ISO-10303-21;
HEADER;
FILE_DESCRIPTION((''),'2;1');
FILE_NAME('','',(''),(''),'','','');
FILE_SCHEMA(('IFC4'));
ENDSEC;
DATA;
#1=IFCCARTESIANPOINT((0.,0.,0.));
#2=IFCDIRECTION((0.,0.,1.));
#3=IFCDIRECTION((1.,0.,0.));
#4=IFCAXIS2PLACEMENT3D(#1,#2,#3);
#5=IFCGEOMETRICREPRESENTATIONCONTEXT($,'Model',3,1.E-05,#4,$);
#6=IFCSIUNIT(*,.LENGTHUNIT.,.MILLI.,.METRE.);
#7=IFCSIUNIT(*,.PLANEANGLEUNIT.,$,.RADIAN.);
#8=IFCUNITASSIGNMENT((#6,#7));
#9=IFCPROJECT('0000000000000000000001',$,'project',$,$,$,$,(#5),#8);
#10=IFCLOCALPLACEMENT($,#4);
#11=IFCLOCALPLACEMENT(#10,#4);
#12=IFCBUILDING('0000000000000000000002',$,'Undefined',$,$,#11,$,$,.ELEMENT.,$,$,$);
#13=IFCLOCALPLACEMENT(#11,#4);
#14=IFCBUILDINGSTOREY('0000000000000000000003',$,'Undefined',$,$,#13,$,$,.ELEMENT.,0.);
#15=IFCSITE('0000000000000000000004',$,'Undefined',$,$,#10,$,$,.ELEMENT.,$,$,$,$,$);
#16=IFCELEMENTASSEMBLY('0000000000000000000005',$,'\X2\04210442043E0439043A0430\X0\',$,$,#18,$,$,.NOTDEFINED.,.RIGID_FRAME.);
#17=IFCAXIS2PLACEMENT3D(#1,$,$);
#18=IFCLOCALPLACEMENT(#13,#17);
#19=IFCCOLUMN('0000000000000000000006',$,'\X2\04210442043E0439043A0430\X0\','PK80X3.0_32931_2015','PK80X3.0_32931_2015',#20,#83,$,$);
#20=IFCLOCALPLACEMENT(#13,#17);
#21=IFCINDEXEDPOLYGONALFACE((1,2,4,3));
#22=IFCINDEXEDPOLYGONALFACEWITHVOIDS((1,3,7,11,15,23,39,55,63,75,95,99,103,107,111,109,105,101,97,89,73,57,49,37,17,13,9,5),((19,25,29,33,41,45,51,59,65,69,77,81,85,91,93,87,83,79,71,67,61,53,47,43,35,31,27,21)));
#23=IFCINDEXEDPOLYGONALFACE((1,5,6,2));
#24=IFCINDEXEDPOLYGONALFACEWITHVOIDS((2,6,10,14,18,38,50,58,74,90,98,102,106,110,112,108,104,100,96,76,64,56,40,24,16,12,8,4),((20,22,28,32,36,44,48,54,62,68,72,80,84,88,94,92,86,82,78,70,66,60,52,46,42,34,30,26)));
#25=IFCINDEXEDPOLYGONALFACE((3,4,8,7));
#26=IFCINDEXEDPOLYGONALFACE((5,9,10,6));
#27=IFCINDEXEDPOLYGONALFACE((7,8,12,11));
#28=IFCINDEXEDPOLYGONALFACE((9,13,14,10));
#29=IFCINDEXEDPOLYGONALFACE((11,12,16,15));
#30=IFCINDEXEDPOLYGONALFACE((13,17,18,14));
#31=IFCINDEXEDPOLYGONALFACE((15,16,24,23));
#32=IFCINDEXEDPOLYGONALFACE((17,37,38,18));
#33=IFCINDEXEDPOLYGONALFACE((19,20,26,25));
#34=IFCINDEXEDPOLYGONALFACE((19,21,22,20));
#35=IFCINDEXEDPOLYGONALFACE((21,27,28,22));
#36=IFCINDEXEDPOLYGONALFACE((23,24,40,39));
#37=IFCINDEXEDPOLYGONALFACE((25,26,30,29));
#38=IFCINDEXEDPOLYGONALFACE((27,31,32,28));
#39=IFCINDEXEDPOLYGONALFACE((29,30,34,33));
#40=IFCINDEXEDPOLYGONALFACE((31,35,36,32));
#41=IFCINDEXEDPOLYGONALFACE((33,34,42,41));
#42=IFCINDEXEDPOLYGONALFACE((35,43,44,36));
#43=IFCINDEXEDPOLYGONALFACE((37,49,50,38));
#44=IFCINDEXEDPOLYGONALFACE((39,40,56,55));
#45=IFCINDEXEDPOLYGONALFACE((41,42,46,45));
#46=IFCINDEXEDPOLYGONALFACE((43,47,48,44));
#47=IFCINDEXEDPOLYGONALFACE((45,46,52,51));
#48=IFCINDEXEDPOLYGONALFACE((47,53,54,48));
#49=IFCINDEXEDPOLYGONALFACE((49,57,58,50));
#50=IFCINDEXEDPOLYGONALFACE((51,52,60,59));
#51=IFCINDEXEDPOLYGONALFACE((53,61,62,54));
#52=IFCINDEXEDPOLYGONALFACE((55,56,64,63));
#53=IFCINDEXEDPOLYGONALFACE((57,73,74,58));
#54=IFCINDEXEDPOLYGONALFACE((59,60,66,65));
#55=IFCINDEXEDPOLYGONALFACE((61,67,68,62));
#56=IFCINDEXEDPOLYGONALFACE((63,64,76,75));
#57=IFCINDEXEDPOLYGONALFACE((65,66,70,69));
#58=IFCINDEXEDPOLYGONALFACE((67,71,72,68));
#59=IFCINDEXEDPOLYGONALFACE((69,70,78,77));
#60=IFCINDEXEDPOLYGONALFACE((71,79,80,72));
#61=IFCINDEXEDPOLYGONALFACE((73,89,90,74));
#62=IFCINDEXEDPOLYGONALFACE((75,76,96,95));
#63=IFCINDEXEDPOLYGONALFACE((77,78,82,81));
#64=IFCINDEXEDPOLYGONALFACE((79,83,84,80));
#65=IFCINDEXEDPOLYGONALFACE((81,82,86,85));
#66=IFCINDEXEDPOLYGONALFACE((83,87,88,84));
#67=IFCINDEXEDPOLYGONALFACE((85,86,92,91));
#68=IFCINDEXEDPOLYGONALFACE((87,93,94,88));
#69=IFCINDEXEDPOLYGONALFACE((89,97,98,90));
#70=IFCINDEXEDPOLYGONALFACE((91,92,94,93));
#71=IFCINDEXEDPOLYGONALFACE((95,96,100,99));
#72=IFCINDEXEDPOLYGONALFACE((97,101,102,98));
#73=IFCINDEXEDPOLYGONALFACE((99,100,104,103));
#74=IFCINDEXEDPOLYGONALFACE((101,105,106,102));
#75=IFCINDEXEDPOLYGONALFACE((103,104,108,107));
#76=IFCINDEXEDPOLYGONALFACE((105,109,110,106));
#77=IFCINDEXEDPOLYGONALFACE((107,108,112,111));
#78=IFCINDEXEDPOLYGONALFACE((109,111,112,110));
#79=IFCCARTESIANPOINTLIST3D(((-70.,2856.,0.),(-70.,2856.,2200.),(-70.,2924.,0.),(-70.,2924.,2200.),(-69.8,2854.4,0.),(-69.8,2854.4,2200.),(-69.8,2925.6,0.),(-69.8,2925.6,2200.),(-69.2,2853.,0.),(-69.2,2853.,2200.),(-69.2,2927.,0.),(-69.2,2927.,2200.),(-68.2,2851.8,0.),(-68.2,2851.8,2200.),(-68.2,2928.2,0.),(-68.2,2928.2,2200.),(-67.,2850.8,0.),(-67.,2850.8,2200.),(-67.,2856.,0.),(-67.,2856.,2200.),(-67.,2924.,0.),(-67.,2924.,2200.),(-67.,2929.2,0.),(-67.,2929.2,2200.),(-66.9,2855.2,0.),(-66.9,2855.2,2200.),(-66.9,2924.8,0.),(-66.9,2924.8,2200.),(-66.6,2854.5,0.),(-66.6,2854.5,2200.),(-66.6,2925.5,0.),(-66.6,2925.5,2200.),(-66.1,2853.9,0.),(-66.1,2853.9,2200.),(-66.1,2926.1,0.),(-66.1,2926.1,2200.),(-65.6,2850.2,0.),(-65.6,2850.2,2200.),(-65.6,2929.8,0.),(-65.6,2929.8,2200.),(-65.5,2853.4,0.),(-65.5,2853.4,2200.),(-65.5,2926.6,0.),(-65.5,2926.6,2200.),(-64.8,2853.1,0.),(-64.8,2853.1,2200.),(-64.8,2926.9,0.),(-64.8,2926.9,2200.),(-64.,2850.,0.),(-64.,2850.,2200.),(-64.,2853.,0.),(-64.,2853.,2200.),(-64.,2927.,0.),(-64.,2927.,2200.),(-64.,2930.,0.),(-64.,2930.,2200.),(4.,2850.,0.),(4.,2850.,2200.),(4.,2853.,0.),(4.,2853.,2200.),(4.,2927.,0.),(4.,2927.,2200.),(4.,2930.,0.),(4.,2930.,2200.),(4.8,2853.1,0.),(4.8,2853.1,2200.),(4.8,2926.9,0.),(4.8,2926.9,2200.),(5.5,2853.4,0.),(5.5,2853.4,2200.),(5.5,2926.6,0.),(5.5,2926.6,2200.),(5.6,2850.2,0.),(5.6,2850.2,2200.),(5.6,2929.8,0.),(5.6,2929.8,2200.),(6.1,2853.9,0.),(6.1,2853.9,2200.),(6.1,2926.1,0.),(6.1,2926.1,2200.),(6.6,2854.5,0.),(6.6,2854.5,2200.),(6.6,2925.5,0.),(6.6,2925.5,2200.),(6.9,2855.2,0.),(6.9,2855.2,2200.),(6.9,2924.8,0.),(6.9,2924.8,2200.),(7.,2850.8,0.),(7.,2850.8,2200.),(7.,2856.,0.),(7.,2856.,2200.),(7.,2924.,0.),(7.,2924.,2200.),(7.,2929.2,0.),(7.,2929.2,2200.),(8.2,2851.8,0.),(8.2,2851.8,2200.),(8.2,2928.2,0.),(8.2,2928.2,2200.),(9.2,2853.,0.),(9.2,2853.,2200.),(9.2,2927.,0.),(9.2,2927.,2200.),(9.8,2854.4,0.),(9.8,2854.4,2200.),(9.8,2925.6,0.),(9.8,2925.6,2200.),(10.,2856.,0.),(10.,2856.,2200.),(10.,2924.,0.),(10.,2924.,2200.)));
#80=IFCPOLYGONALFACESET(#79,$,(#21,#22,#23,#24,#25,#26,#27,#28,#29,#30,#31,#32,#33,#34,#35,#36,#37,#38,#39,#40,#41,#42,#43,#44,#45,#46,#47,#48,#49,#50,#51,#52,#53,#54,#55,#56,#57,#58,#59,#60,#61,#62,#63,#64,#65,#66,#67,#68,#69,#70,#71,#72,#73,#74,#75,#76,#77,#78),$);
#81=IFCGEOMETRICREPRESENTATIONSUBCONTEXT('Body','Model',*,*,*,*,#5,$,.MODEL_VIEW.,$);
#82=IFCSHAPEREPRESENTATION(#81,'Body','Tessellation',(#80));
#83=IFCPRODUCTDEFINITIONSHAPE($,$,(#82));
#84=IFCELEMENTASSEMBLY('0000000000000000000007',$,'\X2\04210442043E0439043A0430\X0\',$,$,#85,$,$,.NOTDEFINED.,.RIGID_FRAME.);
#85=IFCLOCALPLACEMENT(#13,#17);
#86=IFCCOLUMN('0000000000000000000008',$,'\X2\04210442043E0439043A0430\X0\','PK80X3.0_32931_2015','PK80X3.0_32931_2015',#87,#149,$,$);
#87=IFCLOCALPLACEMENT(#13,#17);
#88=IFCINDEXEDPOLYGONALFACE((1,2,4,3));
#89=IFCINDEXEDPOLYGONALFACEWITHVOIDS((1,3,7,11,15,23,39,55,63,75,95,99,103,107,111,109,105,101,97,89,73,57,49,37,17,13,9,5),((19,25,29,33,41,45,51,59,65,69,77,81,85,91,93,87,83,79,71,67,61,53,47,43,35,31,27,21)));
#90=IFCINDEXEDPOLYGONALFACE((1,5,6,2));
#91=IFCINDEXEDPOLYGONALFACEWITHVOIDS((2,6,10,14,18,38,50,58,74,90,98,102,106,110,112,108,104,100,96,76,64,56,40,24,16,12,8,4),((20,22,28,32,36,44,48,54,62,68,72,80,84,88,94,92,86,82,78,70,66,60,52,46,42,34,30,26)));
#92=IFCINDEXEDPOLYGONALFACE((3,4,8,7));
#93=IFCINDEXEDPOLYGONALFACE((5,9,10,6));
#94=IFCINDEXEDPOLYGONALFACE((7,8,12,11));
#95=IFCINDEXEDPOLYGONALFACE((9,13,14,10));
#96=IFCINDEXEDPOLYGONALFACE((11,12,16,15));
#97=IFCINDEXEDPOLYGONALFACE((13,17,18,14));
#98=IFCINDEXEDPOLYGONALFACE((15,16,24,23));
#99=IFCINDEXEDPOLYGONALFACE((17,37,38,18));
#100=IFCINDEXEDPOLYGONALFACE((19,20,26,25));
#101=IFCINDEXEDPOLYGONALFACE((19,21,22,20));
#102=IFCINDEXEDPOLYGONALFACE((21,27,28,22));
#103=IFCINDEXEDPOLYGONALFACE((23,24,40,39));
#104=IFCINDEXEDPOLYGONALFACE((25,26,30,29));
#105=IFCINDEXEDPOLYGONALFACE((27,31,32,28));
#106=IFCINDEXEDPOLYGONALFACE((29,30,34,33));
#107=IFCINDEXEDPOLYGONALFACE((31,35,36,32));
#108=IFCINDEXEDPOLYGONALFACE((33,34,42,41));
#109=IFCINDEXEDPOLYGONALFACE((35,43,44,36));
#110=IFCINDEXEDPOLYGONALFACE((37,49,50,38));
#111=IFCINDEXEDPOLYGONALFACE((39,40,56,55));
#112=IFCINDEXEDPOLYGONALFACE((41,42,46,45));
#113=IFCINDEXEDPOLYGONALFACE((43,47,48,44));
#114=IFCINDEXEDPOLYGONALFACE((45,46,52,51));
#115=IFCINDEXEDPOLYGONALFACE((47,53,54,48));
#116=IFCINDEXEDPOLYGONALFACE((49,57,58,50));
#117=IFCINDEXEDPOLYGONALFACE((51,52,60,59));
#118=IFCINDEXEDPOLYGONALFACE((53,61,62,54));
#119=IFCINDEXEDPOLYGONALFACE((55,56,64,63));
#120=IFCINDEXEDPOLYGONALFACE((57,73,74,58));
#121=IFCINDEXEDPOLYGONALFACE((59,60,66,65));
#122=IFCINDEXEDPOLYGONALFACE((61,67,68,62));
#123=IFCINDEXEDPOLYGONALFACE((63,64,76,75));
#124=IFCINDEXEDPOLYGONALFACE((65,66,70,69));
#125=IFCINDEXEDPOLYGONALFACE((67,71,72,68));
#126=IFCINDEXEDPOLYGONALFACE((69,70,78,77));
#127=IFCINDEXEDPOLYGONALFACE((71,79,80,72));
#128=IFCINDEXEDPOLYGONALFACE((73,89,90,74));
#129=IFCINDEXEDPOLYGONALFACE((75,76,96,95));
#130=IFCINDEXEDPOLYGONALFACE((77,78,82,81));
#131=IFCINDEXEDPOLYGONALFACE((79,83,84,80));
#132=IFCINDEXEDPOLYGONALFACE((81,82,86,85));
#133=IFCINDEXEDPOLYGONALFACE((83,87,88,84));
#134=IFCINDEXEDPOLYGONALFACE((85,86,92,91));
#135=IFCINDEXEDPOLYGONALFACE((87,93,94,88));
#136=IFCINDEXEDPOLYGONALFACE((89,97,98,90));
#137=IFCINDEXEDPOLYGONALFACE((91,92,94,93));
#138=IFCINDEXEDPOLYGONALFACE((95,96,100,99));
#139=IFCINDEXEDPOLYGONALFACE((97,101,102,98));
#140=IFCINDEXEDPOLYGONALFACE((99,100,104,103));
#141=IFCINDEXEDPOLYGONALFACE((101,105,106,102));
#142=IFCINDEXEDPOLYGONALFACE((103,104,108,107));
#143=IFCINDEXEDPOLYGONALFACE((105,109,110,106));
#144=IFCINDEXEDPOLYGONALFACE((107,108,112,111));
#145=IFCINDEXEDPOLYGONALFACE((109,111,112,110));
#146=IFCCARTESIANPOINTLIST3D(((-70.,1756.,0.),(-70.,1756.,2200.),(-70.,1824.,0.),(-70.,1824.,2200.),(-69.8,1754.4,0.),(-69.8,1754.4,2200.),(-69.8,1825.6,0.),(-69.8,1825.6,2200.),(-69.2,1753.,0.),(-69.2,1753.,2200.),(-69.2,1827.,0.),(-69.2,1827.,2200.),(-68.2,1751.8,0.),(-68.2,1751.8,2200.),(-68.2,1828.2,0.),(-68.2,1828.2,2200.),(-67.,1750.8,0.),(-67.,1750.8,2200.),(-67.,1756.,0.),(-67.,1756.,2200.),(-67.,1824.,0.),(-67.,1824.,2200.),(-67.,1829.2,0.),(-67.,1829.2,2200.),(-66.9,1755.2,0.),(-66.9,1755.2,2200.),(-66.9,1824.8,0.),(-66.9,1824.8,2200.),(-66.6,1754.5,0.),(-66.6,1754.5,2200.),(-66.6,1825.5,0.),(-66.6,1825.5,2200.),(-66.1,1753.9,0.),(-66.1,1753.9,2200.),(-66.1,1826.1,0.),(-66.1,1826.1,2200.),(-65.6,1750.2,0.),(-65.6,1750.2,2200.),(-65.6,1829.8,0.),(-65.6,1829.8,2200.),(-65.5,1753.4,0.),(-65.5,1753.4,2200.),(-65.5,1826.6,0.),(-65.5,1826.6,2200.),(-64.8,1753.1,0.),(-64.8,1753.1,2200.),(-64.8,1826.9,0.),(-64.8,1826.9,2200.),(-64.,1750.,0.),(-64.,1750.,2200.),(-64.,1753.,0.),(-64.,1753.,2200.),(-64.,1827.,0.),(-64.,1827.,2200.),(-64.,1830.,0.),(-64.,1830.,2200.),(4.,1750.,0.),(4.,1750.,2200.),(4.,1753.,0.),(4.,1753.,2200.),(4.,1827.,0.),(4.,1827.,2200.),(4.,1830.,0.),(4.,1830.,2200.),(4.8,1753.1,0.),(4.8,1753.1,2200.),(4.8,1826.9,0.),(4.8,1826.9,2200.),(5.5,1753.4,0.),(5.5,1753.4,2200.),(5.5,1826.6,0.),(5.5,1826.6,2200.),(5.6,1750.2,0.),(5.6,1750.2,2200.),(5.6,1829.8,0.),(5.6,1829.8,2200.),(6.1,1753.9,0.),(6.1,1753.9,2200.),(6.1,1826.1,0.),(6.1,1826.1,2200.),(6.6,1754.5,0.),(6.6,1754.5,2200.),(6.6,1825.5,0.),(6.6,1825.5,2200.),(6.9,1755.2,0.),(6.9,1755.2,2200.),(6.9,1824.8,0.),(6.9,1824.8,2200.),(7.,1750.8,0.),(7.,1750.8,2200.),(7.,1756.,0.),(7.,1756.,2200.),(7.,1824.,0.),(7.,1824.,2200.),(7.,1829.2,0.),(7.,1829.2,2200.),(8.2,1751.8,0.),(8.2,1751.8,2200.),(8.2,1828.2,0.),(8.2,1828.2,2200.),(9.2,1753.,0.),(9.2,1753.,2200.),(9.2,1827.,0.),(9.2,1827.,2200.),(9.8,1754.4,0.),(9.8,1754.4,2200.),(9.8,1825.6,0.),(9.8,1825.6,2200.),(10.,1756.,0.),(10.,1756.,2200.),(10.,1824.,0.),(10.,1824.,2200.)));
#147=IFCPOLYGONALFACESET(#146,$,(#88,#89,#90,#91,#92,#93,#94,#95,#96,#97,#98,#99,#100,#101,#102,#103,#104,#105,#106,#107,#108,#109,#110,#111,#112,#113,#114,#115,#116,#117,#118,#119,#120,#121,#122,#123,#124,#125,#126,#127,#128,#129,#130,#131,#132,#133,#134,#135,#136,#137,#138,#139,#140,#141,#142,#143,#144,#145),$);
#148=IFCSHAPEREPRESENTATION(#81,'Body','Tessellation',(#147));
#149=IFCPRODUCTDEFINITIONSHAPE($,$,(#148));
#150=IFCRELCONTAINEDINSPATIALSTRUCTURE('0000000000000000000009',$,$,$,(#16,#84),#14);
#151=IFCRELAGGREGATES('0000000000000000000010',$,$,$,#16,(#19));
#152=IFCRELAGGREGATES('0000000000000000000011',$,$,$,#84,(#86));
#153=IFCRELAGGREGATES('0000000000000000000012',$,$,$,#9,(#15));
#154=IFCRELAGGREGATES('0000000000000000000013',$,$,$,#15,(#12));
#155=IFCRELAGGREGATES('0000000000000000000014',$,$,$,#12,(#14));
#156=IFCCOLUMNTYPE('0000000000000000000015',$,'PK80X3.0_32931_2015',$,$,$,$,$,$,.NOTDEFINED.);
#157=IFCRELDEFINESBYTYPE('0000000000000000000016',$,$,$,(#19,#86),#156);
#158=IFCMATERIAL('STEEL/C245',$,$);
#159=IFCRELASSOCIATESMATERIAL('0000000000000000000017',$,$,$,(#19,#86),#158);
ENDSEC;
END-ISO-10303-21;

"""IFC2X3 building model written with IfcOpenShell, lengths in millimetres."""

from ifc_helpers import new_model, si_unit, frame, origin_with_axes, origin_2d_with_axis, place, context, subcontext, project, spatial, hollow_rectangle, extrude, material, type_object, element, aggregate, save


model = new_model("IFC2X3")

# Units and contexts
model_context = context("Model", 3, precision=1e-05, world=origin_with_axes())
body_context = subcontext(model_context, "Body", "Model", "MODEL_VIEW")
ifc_project = project(units=[si_unit("LENGTHUNIT", "METRE", prefix="MILLI"), si_unit("PLANEANGLEUNIT", "RADIAN")], contexts=[model_context])

# Site, building, storey
site_placement = place(None, origin_with_axes())
site = spatial("IfcSite", under=ifc_project, at=site_placement, Name="Undefined", CompositionType="ELEMENT")
building_placement = place(site_placement, origin_with_axes())
building = spatial("IfcBuilding", under=site, at=building_placement, Name="Undefined", CompositionType="ELEMENT")
storey_placement = place(building_placement, origin_with_axes())
storey = spatial("IfcBuildingStorey", under=building, at=storey_placement, Name="Undefined", CompositionType="ELEMENT", Elevation=0.0)

# Element assemblies, columns
assembly_1_placement = place(storey_placement, origin_with_axes())
assembly_1 = element("IfcElementAssembly", 1, at=assembly_1_placement, inside=storey, Name="Стойка", AssemblyPlace="NOTDEFINED", PredefinedType="RIGID_FRAME")
ifc_material = material(Name="STEEL/C245")
column_type_1 = type_object("IfcColumnType", Name="PK80X3.0_32931_2015", PredefinedType="NOTDEFINED")
column_1_placement = place(assembly_1_placement, frame((-30.0, 2890.0, 0.0), z_axis=(0.0, 0.0, 1.0), x_axis=(1.0, 0.0, 0.0)))
column_1 = element("IfcColumn", 2, at=column_1_placement, type_object=column_type_1, material=ifc_material, Name="Стойка", Description="PK80X3.0_32931_2015", ObjectType="PK80X3.0_32931_2015", context=body_context, shape_type="SweptSolid", body=[
    extrude(hollow_rectangle(XDim=80.0, YDim=80.0, WallThickness=3.0, InnerFilletRadius=3.0, OuterFilletRadius=6.0, at=origin_2d_with_axis()), frame((0.0, 0.0, 2200.0), z_axis=(0.0, 0.0, -1.0), x_axis=(0.0, 1.0, 0.0)), (0.0, 0.0, 1.0), 2200.0),
])
aggregate(assembly_1, [column_1])
assembly_2_placement = place(storey_placement, origin_with_axes())
assembly_2 = element("IfcElementAssembly", 3, at=assembly_2_placement, inside=storey, Name="Стойка", AssemblyPlace="NOTDEFINED", PredefinedType="RIGID_FRAME")
column_2_placement = place(assembly_2_placement, frame((-30.0, 1790.0, 0.0), z_axis=(0.0, 0.0, 1.0), x_axis=(1.0, 0.0, 0.0)))
column_2 = element("IfcColumn", 4, at=column_2_placement, type_object=column_type_1, material=ifc_material, Name="Стойка", Description="PK80X3.0_32931_2015", ObjectType="PK80X3.0_32931_2015", context=body_context, shape_type="SweptSolid", body=[
    extrude(hollow_rectangle(XDim=80.0, YDim=80.0, WallThickness=3.0, InnerFilletRadius=3.0, OuterFilletRadius=6.0, at=origin_2d_with_axis()), frame((0.0, 0.0, 2200.0), z_axis=(0.0, 0.0, -1.0), x_axis=(0.0, 1.0, 0.0)), (0.0, 0.0, 1.0), 2200.0),
])
aggregate(assembly_2, [column_2])

save(model, "model.ifc")
